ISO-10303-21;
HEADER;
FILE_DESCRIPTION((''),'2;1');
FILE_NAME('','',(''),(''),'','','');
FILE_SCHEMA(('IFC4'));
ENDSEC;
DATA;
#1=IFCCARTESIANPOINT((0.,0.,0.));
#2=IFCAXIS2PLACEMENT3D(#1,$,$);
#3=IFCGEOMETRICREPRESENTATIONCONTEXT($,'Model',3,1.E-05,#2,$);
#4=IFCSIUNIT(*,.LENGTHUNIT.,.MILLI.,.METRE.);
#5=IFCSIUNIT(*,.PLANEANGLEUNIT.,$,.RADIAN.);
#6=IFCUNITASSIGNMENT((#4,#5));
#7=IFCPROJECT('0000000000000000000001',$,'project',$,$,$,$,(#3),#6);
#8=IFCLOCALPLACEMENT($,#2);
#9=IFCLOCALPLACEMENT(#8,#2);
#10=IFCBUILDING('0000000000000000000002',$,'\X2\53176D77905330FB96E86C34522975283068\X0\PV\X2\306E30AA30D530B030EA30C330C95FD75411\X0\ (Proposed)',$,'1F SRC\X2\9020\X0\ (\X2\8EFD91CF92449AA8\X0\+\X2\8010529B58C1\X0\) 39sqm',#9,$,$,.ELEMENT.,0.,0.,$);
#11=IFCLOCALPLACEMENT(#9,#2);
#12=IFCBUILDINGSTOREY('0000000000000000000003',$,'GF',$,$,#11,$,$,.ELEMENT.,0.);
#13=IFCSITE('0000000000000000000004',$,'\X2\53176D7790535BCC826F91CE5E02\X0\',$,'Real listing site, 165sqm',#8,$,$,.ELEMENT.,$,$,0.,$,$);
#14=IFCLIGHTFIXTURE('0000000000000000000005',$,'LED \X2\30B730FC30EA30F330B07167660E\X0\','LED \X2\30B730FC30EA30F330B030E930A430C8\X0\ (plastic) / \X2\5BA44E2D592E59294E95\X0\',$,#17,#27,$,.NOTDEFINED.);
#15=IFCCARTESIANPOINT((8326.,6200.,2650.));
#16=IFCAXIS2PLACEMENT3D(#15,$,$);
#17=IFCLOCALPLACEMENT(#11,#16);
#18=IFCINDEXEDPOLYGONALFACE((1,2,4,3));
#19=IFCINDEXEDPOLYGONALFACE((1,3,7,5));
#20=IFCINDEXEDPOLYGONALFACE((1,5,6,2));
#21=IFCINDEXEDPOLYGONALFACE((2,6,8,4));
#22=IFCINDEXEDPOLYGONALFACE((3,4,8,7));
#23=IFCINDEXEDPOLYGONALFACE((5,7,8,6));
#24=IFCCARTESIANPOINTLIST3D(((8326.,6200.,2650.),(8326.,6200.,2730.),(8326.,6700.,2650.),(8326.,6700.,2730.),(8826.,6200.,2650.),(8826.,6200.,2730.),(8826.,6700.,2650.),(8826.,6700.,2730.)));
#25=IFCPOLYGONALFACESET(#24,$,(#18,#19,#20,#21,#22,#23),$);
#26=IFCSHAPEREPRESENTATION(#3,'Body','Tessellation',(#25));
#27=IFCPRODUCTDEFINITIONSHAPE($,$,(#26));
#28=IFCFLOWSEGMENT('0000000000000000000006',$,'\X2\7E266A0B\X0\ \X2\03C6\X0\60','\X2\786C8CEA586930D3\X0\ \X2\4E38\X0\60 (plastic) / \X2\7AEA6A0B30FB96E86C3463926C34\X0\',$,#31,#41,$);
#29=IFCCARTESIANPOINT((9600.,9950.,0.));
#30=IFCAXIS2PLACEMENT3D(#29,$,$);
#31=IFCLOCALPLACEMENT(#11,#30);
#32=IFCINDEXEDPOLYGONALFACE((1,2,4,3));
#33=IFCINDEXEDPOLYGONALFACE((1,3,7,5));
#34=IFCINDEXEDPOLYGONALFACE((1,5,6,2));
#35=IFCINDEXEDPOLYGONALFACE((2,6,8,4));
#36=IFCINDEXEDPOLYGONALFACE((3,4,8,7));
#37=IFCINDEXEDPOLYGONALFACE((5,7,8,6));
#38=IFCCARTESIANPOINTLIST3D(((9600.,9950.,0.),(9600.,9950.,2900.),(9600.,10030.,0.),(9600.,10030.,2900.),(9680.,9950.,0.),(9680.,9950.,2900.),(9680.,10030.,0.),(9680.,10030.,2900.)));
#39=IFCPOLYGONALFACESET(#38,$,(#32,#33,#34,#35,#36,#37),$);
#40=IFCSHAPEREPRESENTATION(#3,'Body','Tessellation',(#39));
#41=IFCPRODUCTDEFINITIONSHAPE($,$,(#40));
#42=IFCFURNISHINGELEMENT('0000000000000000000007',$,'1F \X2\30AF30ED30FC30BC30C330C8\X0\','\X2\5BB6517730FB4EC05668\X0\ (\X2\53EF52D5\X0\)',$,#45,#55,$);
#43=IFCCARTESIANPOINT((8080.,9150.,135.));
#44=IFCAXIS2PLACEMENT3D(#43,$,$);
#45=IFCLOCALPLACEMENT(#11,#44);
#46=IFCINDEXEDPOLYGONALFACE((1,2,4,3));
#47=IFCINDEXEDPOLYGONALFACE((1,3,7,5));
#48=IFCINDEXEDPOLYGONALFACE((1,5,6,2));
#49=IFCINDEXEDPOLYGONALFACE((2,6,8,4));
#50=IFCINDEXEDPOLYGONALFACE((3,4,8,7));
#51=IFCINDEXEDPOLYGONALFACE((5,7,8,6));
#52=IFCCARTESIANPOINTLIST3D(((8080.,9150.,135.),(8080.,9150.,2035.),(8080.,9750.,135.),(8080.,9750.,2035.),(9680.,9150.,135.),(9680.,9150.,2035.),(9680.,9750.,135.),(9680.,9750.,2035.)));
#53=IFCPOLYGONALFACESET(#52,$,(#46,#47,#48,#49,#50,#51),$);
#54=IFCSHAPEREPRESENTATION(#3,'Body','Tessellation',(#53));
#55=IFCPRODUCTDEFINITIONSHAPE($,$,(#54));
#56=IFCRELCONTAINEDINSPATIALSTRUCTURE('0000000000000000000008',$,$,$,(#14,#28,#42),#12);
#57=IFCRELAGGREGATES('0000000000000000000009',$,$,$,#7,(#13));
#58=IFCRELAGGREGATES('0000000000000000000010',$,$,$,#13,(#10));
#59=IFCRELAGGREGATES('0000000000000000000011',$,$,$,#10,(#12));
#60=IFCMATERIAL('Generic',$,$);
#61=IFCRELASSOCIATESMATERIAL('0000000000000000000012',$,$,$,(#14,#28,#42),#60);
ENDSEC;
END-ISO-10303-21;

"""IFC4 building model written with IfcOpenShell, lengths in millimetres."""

from ifc_helpers import new_model, si_unit, frame, frame_2d, origin, place, context, project, spatial, rectangle, extrude, material, element, save


model = new_model("IFC4")

# Units and contexts
model_context = context("Model", 3, precision=1e-05, world=origin())
ifc_project = project(units=[si_unit("LENGTHUNIT", "METRE", prefix="MILLI"), si_unit("PLANEANGLEUNIT", "RADIAN")], contexts=[model_context])

# Site, building, storey
site_placement = place(None, origin())
site = spatial("IfcSite", under=ifc_project, at=site_placement, Name="北海道富良野市", ObjectType="Real listing site, 165sqm", CompositionType="ELEMENT", RefElevation=0.0)
building_placement = place(site_placement, origin())
building = spatial("IfcBuilding", under=site, at=building_placement, Name="北海道・雨水利用とPVのオフグリッド志向 (Proposed)", ObjectType="1F SRC造 (軽量鉄骨+耐力壁) 39sqm", CompositionType="ELEMENT", ElevationOfRefHeight=0.0, ElevationOfTerrain=0.0)
storey_placement = place(building_placement, origin())
storey = spatial("IfcBuildingStorey", under=building, at=storey_placement, Name="GF", CompositionType="ELEMENT", Elevation=0.0)

# Shared definitions
ifc_material_1 = material(Name="Generic")

# Light fixture
light_fixture_placement = place(storey_placement, frame((8326.0, 6200.0, 2650.0)))
element("IfcLightFixture", 1, at=light_fixture_placement, inside=storey, material=ifc_material_1, Name="LED シーリング照明", Description="LED シーリングライト (plastic) / 室中央天井", PredefinedType="NOTDEFINED", context=model_context, shape_type="SweptSolid", body=[
    extrude(rectangle(XDim=500.0, YDim=500.0, at=frame_2d((250.0, 250.0))), frame((8326.0, 6200.0, 2650.0)), (0.0, 0.0, 1.0), 80.0),
])

# Flow segment
flow_segment_placement = place(storey_placement, frame((9600.0, 9950.0, 0.0)))
element("IfcFlowSegment", 2, at=flow_segment_placement, inside=storey, material=ifc_material_1, Name="縦樋 φ60", Description="硬質塩ビ 丸60 (plastic) / 竪樋・雨水排水", context=model_context, shape_type="SweptSolid", body=[
    extrude(rectangle(XDim=80.0, YDim=80.0, at=frame_2d((40.0, 40.0))), frame((9600.0, 9950.0, 0.0)), (0.0, 0.0, 1.0), 2900.0),
])

# Furnishing element
furnishing_placement = place(storey_placement, frame((8080.0, 9150.0, 135.0)))
element("IfcFurnishingElement", 3, at=furnishing_placement, inside=storey, material=ifc_material_1, Name="1F クローゼット", Description="家具・什器 (可動)", context=model_context, shape_type="SweptSolid", body=[
    extrude(rectangle(XDim=1600.0, YDim=600.0, at=frame_2d((800.0, 300.0))), frame((8080.0, 9150.0, 135.0)), (0.0, 0.0, 1.0), 1900.0),
])

save(model, "model.ifc")
